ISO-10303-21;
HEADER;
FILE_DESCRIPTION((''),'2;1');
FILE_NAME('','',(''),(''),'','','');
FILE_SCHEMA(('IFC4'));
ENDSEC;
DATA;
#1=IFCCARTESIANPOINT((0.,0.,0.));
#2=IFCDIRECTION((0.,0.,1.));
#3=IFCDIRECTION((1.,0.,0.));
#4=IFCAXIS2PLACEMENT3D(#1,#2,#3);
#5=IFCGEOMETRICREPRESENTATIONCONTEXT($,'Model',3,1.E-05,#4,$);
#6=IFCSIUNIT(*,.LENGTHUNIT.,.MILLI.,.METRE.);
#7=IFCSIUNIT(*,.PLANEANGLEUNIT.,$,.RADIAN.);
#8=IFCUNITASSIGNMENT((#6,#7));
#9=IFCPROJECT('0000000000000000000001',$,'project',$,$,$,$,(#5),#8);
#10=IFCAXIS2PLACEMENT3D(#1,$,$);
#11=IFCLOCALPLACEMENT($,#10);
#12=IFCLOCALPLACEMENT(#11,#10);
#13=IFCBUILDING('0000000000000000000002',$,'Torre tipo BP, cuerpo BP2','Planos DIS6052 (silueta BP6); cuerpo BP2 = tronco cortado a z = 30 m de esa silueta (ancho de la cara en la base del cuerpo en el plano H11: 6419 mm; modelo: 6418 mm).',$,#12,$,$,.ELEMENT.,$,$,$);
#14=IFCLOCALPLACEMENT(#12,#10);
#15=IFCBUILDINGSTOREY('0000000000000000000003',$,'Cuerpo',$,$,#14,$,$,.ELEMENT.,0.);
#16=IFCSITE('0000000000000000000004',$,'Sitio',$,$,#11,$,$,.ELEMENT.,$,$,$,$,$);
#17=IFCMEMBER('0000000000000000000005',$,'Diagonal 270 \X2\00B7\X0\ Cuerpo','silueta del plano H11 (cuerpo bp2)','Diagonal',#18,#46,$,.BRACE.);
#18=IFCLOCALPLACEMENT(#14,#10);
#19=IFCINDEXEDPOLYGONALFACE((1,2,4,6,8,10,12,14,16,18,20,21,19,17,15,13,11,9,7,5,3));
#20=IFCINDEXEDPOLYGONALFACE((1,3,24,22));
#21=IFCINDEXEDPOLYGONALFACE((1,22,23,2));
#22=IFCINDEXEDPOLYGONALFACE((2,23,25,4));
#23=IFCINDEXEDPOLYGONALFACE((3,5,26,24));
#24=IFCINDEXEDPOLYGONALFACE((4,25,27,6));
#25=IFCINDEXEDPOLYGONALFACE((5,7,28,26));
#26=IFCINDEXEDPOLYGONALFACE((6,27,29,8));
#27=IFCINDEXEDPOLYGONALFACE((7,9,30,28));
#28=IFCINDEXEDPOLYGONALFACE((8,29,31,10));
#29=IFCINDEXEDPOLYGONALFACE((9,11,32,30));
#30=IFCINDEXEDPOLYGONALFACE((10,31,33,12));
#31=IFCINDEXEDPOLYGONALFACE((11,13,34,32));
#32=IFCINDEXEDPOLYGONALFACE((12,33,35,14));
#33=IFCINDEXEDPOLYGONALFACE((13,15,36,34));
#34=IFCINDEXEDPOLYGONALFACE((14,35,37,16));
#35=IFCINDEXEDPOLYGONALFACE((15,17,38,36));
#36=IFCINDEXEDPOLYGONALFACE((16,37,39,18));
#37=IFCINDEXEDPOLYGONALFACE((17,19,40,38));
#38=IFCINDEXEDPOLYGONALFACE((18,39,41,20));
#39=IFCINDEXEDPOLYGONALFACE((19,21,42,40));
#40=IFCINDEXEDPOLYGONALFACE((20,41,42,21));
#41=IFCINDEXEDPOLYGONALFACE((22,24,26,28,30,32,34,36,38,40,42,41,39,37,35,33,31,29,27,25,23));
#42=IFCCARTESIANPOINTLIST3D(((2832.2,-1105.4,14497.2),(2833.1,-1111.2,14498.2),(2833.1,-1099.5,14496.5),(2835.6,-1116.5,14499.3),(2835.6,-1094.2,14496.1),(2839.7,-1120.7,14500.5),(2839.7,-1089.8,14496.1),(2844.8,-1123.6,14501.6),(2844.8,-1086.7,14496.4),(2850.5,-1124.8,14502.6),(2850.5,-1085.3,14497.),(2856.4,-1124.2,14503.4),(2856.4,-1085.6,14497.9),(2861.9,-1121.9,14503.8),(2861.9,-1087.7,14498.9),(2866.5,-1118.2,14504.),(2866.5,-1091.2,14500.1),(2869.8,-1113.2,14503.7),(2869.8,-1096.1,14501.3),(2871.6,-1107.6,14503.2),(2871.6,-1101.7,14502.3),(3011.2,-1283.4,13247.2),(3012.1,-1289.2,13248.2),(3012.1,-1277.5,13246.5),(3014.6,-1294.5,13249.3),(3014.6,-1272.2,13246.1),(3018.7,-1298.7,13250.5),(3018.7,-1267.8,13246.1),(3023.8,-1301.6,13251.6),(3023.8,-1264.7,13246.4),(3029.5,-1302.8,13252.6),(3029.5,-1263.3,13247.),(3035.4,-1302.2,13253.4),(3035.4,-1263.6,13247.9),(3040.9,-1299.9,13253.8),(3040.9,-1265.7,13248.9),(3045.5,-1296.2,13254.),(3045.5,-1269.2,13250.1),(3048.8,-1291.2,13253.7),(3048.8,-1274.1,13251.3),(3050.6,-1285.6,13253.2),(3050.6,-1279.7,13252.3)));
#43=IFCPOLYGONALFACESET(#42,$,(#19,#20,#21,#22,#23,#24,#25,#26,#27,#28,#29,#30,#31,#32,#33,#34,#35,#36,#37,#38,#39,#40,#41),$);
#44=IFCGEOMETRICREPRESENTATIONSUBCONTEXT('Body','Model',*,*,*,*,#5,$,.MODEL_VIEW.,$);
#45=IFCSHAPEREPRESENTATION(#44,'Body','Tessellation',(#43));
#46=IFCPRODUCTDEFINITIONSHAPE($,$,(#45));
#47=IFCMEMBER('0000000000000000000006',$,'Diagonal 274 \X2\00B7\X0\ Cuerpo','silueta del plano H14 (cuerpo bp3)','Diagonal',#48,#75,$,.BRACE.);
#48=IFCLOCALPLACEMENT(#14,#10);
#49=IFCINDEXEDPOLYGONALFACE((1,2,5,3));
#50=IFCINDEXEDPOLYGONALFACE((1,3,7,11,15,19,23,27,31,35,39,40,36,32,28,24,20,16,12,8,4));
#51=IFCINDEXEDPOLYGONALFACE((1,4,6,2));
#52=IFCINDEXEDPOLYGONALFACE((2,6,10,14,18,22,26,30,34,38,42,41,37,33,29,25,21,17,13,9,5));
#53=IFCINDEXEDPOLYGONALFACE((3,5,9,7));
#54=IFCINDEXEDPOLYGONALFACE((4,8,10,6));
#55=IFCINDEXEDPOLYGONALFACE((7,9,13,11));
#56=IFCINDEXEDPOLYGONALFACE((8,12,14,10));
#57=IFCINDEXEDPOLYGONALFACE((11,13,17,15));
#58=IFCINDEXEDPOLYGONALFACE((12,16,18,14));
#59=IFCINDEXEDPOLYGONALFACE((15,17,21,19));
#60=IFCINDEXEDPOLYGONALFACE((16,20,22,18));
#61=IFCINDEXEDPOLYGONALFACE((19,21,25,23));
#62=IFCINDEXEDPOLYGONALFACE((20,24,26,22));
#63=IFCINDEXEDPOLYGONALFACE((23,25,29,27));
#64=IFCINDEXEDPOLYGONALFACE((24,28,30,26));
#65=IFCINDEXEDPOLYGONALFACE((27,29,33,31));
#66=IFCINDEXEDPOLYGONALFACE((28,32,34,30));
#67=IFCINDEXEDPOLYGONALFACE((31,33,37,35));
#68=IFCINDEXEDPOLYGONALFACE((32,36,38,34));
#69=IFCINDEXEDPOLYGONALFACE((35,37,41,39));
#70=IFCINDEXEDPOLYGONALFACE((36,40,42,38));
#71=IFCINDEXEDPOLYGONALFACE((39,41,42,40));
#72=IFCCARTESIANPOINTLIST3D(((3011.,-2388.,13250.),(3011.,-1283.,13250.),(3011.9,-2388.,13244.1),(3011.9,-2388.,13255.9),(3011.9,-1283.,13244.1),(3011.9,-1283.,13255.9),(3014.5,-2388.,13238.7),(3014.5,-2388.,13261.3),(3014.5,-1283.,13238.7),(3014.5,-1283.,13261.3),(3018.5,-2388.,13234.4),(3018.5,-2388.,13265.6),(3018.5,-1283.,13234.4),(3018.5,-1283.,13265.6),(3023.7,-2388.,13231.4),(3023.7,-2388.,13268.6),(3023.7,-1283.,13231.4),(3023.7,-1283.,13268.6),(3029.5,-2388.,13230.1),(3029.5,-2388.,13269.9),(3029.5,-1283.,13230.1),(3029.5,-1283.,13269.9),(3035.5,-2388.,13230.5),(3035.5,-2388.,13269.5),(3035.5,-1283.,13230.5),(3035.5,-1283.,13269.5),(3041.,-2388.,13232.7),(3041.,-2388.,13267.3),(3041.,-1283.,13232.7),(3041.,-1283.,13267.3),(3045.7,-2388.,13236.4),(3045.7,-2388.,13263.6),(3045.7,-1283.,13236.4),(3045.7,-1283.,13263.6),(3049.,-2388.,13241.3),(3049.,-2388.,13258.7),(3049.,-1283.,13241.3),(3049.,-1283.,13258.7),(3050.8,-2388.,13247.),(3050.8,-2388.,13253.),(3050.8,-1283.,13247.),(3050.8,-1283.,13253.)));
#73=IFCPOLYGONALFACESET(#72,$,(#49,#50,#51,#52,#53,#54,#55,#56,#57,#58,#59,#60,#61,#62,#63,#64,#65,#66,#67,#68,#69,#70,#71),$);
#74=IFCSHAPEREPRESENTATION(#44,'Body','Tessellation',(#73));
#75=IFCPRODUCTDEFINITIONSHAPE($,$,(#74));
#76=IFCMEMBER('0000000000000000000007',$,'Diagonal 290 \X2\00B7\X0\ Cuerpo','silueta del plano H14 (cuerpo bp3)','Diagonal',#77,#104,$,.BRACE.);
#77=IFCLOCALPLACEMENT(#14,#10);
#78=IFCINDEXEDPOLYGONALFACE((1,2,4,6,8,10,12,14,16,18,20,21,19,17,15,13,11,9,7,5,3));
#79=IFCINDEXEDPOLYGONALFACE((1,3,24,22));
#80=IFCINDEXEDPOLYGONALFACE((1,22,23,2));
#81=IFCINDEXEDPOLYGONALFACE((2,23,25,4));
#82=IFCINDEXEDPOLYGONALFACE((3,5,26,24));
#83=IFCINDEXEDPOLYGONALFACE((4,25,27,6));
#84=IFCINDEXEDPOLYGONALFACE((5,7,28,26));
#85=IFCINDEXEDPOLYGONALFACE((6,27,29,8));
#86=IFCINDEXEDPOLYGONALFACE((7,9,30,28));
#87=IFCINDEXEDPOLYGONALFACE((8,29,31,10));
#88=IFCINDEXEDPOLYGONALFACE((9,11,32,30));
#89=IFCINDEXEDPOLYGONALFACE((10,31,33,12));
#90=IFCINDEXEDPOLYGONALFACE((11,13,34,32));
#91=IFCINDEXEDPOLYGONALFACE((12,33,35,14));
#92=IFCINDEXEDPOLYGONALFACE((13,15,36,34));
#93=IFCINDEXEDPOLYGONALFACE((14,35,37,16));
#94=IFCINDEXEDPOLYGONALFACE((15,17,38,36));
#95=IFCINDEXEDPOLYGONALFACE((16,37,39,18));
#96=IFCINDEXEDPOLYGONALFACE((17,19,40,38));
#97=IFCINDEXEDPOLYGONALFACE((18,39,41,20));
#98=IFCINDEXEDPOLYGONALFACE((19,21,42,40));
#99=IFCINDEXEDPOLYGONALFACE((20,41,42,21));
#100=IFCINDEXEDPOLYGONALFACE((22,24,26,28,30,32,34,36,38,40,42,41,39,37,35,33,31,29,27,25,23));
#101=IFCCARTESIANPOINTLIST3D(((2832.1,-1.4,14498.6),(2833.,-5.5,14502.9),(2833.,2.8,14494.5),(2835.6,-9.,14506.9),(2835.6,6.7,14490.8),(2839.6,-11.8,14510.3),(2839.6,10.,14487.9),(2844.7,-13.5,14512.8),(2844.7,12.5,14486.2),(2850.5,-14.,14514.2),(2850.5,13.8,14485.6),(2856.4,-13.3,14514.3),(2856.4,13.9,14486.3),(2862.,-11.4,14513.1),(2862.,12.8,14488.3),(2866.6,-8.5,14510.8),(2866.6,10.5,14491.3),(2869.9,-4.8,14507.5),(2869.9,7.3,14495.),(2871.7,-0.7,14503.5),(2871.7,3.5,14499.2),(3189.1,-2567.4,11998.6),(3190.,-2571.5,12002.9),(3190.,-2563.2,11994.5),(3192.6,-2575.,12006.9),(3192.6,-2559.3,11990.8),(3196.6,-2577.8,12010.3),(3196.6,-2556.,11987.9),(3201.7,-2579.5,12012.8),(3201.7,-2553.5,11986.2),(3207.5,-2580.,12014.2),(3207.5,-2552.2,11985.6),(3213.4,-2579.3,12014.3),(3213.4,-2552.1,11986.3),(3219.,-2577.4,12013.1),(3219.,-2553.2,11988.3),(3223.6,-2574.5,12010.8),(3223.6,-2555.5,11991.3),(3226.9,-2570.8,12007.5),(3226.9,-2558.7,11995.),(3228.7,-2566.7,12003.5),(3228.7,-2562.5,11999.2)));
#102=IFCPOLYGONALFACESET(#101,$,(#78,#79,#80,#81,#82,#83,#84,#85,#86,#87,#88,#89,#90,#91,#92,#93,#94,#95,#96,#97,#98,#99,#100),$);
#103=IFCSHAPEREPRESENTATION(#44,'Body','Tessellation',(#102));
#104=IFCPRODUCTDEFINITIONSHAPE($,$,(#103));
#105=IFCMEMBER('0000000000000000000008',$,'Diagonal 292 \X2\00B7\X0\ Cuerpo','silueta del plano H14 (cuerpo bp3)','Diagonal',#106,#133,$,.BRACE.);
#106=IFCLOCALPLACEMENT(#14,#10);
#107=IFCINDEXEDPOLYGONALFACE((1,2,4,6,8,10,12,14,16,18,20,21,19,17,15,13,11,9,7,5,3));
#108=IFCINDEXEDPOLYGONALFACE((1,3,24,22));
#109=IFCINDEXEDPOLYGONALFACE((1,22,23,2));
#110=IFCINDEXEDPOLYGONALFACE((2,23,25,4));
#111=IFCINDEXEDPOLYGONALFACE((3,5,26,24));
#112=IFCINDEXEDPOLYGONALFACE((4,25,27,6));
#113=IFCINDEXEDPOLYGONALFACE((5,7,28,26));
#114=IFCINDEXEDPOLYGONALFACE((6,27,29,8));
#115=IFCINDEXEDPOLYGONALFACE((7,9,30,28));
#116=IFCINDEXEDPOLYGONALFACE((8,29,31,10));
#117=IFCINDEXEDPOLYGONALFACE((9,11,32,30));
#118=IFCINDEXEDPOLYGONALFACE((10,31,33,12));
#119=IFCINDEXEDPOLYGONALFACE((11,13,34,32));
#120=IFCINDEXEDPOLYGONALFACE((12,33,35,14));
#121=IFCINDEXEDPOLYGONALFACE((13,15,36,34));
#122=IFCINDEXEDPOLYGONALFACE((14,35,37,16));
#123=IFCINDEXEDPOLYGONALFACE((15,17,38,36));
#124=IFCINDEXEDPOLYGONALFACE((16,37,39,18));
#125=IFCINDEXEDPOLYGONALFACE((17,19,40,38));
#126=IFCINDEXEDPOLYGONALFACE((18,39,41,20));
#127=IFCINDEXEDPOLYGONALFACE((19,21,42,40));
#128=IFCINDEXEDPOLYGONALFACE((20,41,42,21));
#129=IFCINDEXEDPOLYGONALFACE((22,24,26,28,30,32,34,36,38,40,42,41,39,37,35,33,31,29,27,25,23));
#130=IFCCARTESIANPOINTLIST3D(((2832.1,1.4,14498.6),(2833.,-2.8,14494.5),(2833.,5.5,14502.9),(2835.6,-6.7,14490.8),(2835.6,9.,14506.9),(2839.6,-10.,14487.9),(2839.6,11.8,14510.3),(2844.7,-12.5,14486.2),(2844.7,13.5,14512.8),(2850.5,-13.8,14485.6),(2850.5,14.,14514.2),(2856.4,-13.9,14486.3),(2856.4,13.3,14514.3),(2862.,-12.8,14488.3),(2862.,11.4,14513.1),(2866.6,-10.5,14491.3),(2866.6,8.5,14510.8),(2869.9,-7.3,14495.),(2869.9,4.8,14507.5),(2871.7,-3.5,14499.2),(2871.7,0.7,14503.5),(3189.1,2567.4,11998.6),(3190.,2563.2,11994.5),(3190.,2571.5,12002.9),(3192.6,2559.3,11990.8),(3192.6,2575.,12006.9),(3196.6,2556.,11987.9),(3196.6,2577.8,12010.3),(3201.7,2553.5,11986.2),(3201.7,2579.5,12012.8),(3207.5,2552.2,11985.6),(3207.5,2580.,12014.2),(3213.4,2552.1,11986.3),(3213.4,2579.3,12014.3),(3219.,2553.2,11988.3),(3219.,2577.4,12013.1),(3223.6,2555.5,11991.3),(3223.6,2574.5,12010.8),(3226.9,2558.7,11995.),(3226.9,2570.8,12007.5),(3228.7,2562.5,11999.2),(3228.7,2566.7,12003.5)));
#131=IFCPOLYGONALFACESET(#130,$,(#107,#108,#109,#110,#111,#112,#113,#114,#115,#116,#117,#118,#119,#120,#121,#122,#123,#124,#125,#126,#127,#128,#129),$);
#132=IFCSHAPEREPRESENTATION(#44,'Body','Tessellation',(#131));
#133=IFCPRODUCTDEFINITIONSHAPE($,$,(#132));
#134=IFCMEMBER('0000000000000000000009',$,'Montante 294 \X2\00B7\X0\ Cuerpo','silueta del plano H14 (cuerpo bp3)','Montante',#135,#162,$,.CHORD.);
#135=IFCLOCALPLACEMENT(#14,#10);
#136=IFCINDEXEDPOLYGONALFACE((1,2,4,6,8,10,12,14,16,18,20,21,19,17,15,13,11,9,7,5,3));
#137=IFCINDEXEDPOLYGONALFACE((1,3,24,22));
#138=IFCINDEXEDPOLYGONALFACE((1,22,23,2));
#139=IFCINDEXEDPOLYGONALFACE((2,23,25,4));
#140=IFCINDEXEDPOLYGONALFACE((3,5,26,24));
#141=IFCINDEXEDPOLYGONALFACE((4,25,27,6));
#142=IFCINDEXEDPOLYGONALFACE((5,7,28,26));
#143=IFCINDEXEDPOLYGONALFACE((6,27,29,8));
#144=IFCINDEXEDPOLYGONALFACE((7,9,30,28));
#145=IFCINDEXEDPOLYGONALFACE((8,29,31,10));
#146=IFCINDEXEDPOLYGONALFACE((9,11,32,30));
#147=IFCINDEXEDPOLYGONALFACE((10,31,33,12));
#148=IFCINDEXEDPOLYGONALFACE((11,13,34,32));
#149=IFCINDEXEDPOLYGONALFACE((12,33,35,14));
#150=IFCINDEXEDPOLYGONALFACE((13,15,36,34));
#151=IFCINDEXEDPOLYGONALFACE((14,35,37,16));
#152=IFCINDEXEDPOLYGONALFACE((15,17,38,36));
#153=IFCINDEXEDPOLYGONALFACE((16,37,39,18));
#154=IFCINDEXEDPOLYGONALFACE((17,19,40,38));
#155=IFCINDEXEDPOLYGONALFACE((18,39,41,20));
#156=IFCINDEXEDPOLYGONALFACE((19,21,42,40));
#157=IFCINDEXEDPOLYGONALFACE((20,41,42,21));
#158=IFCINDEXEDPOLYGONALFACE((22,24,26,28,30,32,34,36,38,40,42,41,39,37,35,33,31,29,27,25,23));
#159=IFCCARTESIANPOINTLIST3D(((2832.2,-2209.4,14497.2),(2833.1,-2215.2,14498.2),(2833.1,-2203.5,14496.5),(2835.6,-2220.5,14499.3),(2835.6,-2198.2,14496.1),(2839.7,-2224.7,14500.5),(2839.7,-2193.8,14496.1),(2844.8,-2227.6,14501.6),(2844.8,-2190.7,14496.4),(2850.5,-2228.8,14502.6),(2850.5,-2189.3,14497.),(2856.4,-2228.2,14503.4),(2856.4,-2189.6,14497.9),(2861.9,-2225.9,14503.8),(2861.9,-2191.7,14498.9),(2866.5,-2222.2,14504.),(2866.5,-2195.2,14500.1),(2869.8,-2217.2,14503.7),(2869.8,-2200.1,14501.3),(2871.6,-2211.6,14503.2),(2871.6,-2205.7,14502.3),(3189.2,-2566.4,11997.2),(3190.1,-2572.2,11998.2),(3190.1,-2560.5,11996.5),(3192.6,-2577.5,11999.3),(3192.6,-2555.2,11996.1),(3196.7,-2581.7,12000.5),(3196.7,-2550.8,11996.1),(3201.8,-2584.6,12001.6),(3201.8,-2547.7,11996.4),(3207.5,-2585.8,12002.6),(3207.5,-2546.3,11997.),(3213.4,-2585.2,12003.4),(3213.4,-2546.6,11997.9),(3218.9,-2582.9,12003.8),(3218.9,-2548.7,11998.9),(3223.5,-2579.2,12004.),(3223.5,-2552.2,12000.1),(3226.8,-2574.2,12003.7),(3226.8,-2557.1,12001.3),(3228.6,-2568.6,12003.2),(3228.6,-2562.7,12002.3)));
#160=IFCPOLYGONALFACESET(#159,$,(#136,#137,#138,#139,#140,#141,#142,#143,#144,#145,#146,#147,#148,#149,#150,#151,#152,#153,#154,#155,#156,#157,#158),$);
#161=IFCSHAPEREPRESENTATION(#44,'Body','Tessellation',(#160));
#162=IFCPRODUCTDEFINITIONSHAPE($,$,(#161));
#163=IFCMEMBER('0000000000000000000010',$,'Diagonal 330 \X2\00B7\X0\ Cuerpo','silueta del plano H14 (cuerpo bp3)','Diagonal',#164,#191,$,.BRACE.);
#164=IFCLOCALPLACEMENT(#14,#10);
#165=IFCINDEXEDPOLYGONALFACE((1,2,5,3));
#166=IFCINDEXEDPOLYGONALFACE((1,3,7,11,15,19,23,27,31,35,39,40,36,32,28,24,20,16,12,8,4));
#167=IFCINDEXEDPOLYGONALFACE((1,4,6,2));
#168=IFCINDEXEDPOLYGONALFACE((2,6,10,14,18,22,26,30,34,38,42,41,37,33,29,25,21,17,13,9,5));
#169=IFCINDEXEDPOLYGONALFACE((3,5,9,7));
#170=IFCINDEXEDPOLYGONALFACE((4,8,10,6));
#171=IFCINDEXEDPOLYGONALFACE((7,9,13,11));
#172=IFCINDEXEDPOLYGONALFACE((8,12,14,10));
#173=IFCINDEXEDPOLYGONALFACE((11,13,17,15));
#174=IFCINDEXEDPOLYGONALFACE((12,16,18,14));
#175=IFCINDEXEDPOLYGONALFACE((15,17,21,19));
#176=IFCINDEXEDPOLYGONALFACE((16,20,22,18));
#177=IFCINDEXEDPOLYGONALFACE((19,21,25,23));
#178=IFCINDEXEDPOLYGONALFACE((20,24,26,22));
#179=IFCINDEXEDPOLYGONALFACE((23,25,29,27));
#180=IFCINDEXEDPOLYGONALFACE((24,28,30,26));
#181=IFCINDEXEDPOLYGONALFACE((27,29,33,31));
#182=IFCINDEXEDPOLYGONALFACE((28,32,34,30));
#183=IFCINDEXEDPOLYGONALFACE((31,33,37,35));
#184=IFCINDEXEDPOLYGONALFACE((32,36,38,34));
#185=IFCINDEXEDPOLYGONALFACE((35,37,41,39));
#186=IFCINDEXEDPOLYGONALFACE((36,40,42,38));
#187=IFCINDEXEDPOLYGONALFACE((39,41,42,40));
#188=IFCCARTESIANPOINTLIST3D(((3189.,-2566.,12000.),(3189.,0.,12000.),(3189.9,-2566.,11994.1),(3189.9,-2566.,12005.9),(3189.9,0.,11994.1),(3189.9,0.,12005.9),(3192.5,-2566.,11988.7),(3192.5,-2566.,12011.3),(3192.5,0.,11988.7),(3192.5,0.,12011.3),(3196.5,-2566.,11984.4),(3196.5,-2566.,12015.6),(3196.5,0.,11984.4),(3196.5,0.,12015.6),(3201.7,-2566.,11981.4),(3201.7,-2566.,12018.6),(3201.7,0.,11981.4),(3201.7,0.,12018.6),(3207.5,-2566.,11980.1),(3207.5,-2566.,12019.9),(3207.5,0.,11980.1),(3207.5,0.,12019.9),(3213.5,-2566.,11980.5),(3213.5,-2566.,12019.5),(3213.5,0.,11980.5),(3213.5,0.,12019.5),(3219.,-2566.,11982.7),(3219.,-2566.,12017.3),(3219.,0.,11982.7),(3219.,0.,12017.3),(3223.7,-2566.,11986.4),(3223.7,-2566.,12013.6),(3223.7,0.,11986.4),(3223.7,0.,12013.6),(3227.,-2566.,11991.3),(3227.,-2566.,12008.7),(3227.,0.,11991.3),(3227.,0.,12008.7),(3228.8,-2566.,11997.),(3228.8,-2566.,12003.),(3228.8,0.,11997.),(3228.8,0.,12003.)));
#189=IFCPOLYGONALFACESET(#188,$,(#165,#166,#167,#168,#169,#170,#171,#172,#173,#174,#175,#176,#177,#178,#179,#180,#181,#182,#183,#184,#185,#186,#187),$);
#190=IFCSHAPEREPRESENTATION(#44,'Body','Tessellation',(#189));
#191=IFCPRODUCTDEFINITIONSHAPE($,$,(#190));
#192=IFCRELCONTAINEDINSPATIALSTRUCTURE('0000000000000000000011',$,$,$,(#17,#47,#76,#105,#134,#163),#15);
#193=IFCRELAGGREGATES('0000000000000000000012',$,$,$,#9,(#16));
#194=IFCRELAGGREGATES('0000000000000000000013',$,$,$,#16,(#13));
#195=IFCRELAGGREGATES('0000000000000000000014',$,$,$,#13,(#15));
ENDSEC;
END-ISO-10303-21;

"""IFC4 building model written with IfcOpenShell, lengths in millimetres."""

from ifc_helpers import new_model, si_unit, frame, origin, origin_with_axes, place, context, subcontext, project, spatial, circle, extrude, element, save


model = new_model("IFC4")

# Units and contexts
model_context = context("Model", 3, precision=1e-05, world=origin_with_axes())
body_context = subcontext(model_context, "Body", "Model", "MODEL_VIEW")
ifc_project = project(units=[si_unit("LENGTHUNIT", "METRE", prefix="MILLI"), si_unit("PLANEANGLEUNIT", "RADIAN")], contexts=[model_context])

# Site, building, storey
site_placement = place(None, origin())
site = spatial("IfcSite", under=ifc_project, at=site_placement, Name="Sitio", CompositionType="ELEMENT")
building_placement = place(site_placement, origin())
building = spatial("IfcBuilding", under=site, at=building_placement, Name="Torre tipo BP, cuerpo BP2", Description="Planos DIS6052 (silueta BP6); cuerpo BP2 = tronco cortado a z = 30 m de esa silueta (ancho de la cara en la base del cuerpo en el plano H11: 6419 mm; modelo: 6418 mm).", CompositionType="ELEMENT")
storey_placement = place(building_placement, origin())
storey = spatial("IfcBuildingStorey", under=building, at=storey_placement, Name="Cuerpo", CompositionType="ELEMENT", Elevation=0.0)

# Members
member_1_placement = place(storey_placement, frame((2852.0, -1105.0, 14500.0), z_axis=(0.140366, -0.139582, -0.980211), x_axis=(-0.9901, -0.019789, -0.138964)))
element("IfcMember", 1, at=member_1_placement, inside=storey, Name="Diagonal 270 · Cuerpo", Description="silueta del plano H11 (cuerpo bp2)", ObjectType="Diagonal", PredefinedType="BRACE", context=body_context, shape_type="SweptSolid", body=[
    extrude(circle(Radius=20.0), None, (0.0, 0.0, 1.0), 1275.2),
])
member_2_placement = place(storey_placement, frame((3031.0, -1283.0, 13250.0), z_axis=(0.0, -1.0, 0.0), x_axis=(-1.0, 0.0, 0.0)))
element("IfcMember", 2, at=member_2_placement, inside=storey, Name="Diagonal 274 · Cuerpo", Description="silueta del plano H14 (cuerpo bp3)", ObjectType="Diagonal", PredefinedType="BRACE", context=body_context, shape_type="SweptSolid", body=[
    extrude(circle(Radius=20.0), None, (0.0, 0.0, 1.0), 1105.0),
])
for number, where, z_axis, x_axis, name in (
    (3, (2852.0, 0.0, 14500.0), (0.09916, -0.712728, -0.694396), (-0.995072, -0.071024, -0.069197), "Diagonal 290 · Cuerpo"),
    (4, (2852.0, 0.0, 14500.0), (0.09916, 0.712728, -0.694396), (-0.995072, 0.071024, -0.069197), "Diagonal 292 · Cuerpo"),
):
    element("IfcMember", number, at=place(storey_placement, frame(where, z_axis=z_axis, x_axis=x_axis)), inside=storey, Name=name, Description="silueta del plano H14 (cuerpo bp3)", ObjectType="Diagonal", PredefinedType="BRACE", context=body_context, shape_type="SweptSolid", body=[
        extrude(circle(Radius=20.0), None, (0.0, 0.0, 1.0), 3600.3),
    ])
member_3_placement = place(storey_placement, frame((2852.0, -2209.0, 14500.0), z_axis=(0.139974, -0.139974, -0.980211), x_axis=(-0.990155, -0.019788, -0.138568)))
element("IfcMember", 5, at=member_3_placement, inside=storey, Name="Montante 294 · Cuerpo", Description="silueta del plano H14 (cuerpo bp3)", ObjectType="Montante", PredefinedType="CHORD", context=body_context, shape_type="SweptSolid", body=[
    extrude(circle(Radius=20.0), None, (0.0, 0.0, 1.0), 2550.5),
])
for number, where, z_axis, x_axis, name in (
    (6, (3209.0, -2566.0, 12000.0), (0.0, 1.0, 0.0), (-1.0, 0.0, 0.0), "Diagonal 330 · Cuerpo"),
):
    element("IfcMember", number, at=place(storey_placement, frame(where, z_axis=z_axis, x_axis=x_axis)), inside=storey, Name=name, Description="silueta del plano H14 (cuerpo bp3)", ObjectType="Diagonal", PredefinedType="BRACE", context=body_context, shape_type="SweptSolid", body=[
        extrude(circle(Radius=20.0), None, (0.0, 0.0, 1.0), 2566.0),
    ])

save(model, "model.ifc")
